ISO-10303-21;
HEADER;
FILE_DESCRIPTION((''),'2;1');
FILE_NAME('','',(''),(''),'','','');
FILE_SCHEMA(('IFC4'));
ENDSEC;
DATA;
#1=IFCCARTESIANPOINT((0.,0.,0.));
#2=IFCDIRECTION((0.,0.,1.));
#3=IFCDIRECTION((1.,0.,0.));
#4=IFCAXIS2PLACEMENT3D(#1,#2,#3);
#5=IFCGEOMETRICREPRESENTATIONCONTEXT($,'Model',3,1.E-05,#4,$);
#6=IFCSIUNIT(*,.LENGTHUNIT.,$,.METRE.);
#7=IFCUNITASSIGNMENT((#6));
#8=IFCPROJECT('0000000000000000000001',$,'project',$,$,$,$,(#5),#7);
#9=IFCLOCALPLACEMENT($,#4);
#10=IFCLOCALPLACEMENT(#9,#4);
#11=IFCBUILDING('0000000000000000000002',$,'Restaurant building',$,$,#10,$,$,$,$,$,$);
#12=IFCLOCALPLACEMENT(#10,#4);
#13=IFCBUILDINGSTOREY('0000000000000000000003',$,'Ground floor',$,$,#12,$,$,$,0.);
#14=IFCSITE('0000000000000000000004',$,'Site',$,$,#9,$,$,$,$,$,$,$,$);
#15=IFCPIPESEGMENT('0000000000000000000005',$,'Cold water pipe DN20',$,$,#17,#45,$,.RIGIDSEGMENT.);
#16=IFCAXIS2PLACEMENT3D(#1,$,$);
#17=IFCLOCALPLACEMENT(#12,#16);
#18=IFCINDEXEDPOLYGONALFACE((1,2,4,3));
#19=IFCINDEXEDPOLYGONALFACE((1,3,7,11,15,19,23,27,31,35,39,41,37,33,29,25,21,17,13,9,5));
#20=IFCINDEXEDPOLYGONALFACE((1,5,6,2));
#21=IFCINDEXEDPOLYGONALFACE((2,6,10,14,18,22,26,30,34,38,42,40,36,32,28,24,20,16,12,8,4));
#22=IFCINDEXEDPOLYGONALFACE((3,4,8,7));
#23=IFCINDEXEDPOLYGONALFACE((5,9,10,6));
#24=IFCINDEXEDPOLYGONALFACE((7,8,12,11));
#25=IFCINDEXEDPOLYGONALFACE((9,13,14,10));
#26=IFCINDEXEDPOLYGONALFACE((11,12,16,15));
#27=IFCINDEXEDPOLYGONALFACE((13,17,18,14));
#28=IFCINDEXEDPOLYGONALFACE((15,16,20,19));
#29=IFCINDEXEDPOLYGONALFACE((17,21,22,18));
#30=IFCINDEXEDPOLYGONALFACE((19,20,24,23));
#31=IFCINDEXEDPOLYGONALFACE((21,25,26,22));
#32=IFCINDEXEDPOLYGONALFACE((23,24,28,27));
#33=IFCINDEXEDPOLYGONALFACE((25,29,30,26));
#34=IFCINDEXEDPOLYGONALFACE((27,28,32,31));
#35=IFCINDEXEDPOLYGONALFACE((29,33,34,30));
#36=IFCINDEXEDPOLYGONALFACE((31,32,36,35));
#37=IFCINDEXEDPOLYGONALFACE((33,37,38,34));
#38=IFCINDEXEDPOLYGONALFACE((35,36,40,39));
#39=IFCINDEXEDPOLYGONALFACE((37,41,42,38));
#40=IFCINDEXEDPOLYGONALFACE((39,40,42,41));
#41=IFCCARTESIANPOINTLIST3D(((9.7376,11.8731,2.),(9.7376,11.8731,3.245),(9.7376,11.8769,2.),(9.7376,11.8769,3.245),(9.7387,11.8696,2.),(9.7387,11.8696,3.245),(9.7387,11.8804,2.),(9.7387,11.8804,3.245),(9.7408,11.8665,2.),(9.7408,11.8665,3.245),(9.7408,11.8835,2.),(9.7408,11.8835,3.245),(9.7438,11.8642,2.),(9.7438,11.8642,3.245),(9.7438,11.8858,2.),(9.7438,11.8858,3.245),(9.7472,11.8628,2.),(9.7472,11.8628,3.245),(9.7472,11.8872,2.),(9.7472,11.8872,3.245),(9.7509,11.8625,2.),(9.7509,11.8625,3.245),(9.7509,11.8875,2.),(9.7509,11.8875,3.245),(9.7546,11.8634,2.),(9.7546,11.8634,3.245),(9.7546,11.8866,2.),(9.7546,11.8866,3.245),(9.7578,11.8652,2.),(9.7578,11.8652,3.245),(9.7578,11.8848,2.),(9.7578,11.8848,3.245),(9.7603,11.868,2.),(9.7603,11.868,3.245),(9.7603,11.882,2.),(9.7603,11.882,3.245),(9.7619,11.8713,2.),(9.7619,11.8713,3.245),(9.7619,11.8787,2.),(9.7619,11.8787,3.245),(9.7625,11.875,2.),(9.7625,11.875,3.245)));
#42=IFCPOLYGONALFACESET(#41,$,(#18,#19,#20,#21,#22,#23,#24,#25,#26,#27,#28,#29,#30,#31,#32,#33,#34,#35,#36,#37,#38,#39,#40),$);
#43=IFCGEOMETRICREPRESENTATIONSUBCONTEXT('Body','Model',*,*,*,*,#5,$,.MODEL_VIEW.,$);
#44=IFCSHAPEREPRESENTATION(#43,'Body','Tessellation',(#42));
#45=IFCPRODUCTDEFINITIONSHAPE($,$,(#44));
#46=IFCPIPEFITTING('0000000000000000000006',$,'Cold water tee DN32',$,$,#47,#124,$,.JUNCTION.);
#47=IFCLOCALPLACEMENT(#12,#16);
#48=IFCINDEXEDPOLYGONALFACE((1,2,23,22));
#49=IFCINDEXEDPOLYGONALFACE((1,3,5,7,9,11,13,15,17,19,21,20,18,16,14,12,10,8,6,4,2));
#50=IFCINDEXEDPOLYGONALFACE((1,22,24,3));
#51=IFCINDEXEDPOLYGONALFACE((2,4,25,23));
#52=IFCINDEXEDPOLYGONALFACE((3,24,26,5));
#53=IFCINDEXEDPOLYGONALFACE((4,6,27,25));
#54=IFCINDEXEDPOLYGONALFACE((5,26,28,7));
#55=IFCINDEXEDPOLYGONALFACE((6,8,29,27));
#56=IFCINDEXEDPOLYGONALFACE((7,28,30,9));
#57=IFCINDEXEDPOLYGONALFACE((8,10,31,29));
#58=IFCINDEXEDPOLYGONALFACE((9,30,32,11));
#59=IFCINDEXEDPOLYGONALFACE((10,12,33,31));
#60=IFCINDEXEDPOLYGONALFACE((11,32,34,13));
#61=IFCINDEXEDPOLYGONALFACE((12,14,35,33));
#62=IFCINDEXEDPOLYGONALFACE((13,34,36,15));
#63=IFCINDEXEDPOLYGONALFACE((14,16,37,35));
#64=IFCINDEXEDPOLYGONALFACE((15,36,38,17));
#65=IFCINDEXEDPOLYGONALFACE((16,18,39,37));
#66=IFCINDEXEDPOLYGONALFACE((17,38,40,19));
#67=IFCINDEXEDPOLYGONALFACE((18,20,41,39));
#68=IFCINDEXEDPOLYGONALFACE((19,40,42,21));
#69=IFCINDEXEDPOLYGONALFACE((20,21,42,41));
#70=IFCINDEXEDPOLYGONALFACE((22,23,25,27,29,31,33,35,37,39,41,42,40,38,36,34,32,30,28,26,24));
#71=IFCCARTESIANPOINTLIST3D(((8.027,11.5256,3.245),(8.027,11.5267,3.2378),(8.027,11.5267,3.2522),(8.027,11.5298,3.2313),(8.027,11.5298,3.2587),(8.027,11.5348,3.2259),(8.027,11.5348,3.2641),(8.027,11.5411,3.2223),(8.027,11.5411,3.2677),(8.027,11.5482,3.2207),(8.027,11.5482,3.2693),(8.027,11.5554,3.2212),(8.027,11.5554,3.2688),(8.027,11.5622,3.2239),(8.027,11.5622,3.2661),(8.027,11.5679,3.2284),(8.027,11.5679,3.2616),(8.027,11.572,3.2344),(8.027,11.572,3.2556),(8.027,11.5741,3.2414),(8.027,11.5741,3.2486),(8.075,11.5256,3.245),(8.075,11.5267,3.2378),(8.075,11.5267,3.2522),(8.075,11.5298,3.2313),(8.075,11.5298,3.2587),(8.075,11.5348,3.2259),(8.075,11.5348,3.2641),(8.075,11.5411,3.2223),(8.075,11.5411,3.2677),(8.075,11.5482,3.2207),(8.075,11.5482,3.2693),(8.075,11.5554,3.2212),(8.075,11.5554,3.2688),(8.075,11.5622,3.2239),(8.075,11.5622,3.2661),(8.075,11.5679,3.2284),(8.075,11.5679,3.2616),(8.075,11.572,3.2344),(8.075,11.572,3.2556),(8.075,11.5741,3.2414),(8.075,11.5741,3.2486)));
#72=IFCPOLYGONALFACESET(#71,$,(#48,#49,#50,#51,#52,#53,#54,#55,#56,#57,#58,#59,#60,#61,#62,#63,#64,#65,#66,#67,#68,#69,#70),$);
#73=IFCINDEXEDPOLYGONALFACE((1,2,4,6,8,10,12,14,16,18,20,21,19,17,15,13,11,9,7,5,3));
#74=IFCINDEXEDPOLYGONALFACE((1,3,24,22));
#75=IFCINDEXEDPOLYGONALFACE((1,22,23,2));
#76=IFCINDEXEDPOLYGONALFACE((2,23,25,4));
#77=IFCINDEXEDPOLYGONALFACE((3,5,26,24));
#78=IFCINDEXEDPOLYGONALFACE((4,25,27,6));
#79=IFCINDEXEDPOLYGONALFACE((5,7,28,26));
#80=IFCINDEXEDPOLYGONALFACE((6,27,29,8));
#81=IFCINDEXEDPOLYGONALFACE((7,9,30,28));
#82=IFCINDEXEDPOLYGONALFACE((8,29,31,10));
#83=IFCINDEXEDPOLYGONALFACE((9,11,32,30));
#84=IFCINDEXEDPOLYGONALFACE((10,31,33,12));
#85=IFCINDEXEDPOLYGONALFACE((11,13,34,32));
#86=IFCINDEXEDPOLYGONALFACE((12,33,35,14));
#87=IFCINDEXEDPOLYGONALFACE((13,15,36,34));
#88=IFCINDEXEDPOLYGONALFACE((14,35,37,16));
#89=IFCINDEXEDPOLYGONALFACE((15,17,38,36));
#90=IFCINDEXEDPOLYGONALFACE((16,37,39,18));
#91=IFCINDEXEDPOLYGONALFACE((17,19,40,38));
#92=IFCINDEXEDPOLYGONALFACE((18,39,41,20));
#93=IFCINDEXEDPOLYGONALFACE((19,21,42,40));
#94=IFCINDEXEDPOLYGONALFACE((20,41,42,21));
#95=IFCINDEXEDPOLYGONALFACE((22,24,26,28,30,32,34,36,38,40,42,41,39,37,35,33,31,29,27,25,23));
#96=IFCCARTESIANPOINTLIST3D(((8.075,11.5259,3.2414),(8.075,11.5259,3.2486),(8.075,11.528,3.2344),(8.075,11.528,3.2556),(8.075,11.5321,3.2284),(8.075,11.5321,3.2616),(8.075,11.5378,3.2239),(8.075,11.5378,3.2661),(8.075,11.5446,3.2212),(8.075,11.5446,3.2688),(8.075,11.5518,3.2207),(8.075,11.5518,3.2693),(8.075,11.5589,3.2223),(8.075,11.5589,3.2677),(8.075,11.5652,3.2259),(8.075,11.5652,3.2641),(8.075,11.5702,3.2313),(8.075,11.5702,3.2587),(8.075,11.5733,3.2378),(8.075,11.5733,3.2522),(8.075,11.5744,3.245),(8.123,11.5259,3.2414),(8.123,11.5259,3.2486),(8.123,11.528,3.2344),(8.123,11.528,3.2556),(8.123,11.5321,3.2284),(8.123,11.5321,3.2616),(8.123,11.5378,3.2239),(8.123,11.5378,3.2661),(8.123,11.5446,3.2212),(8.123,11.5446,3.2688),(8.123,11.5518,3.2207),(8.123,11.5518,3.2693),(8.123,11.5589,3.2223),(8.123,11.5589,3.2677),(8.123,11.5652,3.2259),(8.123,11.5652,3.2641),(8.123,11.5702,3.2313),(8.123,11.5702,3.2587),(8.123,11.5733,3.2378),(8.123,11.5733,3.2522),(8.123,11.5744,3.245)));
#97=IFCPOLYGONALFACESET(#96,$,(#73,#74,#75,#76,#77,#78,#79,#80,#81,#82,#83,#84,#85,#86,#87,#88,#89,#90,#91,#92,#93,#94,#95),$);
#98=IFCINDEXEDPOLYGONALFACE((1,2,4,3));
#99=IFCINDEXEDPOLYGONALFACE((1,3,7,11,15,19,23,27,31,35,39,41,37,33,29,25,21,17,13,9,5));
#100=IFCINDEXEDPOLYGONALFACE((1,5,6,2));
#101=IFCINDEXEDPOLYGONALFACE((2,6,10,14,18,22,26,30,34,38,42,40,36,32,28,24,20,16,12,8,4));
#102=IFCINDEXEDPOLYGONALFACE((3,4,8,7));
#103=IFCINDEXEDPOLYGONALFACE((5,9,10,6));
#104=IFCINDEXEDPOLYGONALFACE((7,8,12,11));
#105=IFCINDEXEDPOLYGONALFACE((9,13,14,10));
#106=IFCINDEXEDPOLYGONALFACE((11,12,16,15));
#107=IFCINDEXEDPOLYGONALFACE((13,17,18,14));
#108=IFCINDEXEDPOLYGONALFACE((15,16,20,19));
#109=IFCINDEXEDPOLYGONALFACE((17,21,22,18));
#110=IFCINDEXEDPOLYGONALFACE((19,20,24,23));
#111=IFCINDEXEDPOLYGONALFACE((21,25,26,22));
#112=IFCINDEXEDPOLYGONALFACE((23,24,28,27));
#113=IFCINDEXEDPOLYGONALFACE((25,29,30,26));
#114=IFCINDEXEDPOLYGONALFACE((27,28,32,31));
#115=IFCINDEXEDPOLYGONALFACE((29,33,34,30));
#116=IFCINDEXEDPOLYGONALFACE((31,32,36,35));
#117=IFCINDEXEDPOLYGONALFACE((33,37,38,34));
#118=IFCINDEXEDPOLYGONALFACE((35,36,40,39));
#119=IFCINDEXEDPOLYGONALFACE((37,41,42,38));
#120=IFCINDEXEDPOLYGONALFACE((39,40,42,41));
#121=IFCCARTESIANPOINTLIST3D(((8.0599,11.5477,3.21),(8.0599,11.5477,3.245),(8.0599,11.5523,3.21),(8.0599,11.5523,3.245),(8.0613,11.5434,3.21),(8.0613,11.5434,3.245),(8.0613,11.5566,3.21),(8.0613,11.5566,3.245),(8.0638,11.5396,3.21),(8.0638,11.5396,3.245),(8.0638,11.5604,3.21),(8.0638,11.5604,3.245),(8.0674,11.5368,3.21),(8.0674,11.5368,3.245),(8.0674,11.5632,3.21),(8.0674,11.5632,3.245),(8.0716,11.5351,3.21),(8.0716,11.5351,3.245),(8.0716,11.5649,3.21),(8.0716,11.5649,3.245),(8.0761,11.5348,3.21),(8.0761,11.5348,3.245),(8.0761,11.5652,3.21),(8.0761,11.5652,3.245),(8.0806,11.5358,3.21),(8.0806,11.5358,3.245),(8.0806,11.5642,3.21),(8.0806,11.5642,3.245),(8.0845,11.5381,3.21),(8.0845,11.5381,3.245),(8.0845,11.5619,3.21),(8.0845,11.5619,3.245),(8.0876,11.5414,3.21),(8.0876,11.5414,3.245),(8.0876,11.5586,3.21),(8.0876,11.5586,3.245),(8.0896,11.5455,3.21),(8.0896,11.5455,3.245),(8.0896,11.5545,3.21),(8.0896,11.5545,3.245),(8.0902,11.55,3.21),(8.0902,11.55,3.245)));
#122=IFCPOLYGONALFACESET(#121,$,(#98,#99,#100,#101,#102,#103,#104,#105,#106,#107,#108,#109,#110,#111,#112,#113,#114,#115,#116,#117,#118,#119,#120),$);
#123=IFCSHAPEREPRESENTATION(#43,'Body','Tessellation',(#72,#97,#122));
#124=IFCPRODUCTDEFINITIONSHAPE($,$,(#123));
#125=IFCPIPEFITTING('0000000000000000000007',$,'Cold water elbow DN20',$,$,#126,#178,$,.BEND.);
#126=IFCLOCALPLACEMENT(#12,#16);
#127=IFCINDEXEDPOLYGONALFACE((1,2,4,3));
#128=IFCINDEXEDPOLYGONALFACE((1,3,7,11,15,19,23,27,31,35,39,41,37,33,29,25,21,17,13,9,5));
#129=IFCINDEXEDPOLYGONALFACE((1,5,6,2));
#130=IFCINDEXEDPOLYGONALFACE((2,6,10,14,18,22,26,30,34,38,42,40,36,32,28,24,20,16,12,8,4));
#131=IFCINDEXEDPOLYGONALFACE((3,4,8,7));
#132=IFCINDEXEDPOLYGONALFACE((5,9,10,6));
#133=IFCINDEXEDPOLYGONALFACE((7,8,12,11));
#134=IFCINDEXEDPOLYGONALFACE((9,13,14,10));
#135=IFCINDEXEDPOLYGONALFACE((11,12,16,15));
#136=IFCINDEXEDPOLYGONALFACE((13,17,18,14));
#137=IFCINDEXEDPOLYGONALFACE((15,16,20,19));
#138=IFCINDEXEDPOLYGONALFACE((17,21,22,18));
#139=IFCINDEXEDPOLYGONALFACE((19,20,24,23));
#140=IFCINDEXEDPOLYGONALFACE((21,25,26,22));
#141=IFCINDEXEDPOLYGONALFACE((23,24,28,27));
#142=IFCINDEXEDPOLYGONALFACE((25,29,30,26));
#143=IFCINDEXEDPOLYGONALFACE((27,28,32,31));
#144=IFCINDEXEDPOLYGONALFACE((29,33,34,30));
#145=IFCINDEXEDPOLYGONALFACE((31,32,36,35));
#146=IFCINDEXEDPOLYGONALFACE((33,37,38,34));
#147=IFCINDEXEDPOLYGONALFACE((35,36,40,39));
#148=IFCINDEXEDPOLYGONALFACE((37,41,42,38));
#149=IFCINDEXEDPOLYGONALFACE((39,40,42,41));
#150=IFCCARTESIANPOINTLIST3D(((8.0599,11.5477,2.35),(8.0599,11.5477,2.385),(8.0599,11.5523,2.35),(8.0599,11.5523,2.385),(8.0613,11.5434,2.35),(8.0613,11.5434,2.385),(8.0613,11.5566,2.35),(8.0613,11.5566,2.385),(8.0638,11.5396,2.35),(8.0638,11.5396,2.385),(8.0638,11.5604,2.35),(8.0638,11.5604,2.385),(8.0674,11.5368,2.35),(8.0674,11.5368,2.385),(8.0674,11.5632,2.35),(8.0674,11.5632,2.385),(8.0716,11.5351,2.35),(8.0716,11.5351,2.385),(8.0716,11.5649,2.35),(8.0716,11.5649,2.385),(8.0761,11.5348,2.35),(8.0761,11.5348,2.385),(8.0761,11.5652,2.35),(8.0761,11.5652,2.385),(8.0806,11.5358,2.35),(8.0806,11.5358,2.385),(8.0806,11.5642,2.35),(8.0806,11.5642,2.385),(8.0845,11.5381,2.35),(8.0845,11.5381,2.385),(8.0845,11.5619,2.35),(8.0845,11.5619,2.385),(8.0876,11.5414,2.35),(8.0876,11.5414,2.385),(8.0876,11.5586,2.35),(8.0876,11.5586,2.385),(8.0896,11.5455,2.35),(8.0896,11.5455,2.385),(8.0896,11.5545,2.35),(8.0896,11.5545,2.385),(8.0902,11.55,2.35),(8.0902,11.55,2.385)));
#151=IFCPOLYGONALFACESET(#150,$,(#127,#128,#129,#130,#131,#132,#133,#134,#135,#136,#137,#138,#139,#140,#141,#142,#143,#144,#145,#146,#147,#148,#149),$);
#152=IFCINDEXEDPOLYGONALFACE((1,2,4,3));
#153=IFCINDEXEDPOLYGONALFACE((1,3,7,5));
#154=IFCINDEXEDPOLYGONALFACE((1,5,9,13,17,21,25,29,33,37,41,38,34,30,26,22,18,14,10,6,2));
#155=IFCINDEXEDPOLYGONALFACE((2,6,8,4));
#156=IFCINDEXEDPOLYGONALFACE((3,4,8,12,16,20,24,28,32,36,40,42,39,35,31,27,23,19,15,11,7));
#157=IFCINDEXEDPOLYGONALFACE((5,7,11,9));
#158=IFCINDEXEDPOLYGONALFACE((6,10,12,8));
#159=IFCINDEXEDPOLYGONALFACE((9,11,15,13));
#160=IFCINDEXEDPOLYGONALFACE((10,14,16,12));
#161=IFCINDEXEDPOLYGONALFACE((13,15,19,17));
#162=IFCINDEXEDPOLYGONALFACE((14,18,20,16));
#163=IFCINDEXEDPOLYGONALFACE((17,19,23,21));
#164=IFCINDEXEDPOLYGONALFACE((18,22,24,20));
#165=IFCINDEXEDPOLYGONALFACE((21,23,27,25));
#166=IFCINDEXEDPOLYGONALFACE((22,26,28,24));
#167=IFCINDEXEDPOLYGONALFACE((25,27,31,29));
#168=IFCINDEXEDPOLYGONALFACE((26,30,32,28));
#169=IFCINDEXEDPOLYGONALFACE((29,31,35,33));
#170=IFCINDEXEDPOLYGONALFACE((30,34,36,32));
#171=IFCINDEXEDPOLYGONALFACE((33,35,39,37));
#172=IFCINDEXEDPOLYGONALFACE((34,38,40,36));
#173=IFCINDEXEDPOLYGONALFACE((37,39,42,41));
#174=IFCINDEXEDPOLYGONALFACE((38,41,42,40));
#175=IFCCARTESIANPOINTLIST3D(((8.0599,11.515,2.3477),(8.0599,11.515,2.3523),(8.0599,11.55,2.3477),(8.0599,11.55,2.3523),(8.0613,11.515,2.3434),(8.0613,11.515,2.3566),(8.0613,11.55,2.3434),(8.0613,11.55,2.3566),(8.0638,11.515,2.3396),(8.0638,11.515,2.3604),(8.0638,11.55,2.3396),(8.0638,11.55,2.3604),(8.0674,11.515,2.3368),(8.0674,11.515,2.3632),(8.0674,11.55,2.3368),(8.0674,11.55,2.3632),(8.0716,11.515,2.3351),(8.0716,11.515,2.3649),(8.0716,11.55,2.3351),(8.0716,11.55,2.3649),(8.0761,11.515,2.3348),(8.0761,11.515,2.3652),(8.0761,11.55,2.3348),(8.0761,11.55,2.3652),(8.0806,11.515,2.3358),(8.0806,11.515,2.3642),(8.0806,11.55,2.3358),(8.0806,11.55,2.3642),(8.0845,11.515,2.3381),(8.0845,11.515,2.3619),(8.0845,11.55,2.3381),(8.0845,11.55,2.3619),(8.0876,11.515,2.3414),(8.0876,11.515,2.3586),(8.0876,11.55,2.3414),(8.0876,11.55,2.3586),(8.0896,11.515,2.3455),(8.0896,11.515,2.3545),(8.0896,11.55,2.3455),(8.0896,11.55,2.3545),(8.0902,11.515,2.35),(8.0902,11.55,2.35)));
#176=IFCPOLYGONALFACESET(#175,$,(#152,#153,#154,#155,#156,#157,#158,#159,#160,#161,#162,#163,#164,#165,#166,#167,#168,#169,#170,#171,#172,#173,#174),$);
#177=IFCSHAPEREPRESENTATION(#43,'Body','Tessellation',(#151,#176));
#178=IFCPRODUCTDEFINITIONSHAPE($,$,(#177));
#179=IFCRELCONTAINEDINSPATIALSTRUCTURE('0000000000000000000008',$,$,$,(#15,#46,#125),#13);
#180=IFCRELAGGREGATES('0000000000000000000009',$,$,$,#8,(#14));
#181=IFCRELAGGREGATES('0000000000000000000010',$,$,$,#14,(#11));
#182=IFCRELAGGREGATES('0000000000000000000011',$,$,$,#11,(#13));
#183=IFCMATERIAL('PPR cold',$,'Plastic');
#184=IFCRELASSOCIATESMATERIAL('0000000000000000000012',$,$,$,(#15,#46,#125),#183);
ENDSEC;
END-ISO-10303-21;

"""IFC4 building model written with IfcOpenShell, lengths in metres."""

from ifc_helpers import new_model, si_unit, frame, origin, origin_with_axes, origin_2d, place, context, subcontext, project, spatial, circle, extrude, material, element, save


model = new_model("IFC4")

# Units and contexts
model_context = context("Model", 3, precision=1e-05, world=origin_with_axes())
body_context = subcontext(model_context, "Body", "Model", "MODEL_VIEW")
ifc_project = project(units=[si_unit("LENGTHUNIT", "METRE")], contexts=[model_context])

# Site, building, storey
site_placement = place(None, origin_with_axes())
site = spatial("IfcSite", under=ifc_project, at=site_placement, Name="Site")
building_placement = place(site_placement, origin_with_axes())
building = spatial("IfcBuilding", under=site, at=building_placement, Name="Restaurant building")
storey_placement = place(building_placement, origin_with_axes())
storey = spatial("IfcBuildingStorey", under=building, at=storey_placement, Name="Ground floor", Elevation=0.0)

# Pipe segment
ifc_material_1 = material(Name="PPR cold", Category="Plastic")
pipe_segment_1_placement = place(storey_placement, frame((9.75, 11.875, 3.245)))
element("IfcPipeSegment", 1, at=pipe_segment_1_placement, inside=storey, material=ifc_material_1, Name="Cold water pipe DN20", PredefinedType="RIGIDSEGMENT", context=body_context, shape_type="SweptSolid", body=[
    extrude(circle(Radius=0.0125, at=origin_2d()), frame((0.0, 0.0, 0.0), z_axis=(0.0, 0.0, -1.0), x_axis=(1.0, 0.0, 0.0)), (0.0, 0.0, 1.0), 1.245),
])

# Pipe fittings
pipe_fitting_1_placement = place(storey_placement, frame((8.075, 11.55, 3.245)))
element("IfcPipeFitting", 2, at=pipe_fitting_1_placement, inside=storey, material=ifc_material_1, Name="Cold water tee DN32", PredefinedType="JUNCTION", context=body_context, shape_type="SweptSolid", body=[
    extrude(circle(Radius=0.0244, at=origin_2d()), frame((0.0, 0.0, 0.0), z_axis=(-1.0, 0.0, 0.0), x_axis=(0.0, -1.0, 0.0)), (0.0, 0.0, 1.0), 0.048),
    extrude(circle(Radius=0.0244, at=origin_2d()), frame((0.0, 0.0, 0.0), z_axis=(1.0, 0.0, 0.0), x_axis=(0.0, 1.0, 0.0)), (0.0, 0.0, 1.0), 0.048),
    extrude(circle(Radius=0.0152, at=origin_2d()), frame((0.0, 0.0, 0.0), z_axis=(0.0, 0.0, -1.0), x_axis=(1.0, 0.0, 0.0)), (0.0, 0.0, 1.0), 0.035),
])
pipe_fitting_2_placement = place(storey_placement, frame((8.075, 11.55, 2.35)))
element("IfcPipeFitting", 3, at=pipe_fitting_2_placement, inside=storey, material=ifc_material_1, Name="Cold water elbow DN20", PredefinedType="BEND", context=body_context, shape_type="SweptSolid", body=[
    extrude(circle(Radius=0.0152, at=origin_2d()), origin(), (0.0, 0.0, 1.0), 0.035),
    extrude(circle(Radius=0.0152, at=origin_2d()), frame((0.0, 0.0, 0.0), z_axis=(0.0, -1.0, 0.0), x_axis=(1.0, 0.0, 0.0)), (0.0, 0.0, 1.0), 0.035),
])

save(model, "model.ifc")
